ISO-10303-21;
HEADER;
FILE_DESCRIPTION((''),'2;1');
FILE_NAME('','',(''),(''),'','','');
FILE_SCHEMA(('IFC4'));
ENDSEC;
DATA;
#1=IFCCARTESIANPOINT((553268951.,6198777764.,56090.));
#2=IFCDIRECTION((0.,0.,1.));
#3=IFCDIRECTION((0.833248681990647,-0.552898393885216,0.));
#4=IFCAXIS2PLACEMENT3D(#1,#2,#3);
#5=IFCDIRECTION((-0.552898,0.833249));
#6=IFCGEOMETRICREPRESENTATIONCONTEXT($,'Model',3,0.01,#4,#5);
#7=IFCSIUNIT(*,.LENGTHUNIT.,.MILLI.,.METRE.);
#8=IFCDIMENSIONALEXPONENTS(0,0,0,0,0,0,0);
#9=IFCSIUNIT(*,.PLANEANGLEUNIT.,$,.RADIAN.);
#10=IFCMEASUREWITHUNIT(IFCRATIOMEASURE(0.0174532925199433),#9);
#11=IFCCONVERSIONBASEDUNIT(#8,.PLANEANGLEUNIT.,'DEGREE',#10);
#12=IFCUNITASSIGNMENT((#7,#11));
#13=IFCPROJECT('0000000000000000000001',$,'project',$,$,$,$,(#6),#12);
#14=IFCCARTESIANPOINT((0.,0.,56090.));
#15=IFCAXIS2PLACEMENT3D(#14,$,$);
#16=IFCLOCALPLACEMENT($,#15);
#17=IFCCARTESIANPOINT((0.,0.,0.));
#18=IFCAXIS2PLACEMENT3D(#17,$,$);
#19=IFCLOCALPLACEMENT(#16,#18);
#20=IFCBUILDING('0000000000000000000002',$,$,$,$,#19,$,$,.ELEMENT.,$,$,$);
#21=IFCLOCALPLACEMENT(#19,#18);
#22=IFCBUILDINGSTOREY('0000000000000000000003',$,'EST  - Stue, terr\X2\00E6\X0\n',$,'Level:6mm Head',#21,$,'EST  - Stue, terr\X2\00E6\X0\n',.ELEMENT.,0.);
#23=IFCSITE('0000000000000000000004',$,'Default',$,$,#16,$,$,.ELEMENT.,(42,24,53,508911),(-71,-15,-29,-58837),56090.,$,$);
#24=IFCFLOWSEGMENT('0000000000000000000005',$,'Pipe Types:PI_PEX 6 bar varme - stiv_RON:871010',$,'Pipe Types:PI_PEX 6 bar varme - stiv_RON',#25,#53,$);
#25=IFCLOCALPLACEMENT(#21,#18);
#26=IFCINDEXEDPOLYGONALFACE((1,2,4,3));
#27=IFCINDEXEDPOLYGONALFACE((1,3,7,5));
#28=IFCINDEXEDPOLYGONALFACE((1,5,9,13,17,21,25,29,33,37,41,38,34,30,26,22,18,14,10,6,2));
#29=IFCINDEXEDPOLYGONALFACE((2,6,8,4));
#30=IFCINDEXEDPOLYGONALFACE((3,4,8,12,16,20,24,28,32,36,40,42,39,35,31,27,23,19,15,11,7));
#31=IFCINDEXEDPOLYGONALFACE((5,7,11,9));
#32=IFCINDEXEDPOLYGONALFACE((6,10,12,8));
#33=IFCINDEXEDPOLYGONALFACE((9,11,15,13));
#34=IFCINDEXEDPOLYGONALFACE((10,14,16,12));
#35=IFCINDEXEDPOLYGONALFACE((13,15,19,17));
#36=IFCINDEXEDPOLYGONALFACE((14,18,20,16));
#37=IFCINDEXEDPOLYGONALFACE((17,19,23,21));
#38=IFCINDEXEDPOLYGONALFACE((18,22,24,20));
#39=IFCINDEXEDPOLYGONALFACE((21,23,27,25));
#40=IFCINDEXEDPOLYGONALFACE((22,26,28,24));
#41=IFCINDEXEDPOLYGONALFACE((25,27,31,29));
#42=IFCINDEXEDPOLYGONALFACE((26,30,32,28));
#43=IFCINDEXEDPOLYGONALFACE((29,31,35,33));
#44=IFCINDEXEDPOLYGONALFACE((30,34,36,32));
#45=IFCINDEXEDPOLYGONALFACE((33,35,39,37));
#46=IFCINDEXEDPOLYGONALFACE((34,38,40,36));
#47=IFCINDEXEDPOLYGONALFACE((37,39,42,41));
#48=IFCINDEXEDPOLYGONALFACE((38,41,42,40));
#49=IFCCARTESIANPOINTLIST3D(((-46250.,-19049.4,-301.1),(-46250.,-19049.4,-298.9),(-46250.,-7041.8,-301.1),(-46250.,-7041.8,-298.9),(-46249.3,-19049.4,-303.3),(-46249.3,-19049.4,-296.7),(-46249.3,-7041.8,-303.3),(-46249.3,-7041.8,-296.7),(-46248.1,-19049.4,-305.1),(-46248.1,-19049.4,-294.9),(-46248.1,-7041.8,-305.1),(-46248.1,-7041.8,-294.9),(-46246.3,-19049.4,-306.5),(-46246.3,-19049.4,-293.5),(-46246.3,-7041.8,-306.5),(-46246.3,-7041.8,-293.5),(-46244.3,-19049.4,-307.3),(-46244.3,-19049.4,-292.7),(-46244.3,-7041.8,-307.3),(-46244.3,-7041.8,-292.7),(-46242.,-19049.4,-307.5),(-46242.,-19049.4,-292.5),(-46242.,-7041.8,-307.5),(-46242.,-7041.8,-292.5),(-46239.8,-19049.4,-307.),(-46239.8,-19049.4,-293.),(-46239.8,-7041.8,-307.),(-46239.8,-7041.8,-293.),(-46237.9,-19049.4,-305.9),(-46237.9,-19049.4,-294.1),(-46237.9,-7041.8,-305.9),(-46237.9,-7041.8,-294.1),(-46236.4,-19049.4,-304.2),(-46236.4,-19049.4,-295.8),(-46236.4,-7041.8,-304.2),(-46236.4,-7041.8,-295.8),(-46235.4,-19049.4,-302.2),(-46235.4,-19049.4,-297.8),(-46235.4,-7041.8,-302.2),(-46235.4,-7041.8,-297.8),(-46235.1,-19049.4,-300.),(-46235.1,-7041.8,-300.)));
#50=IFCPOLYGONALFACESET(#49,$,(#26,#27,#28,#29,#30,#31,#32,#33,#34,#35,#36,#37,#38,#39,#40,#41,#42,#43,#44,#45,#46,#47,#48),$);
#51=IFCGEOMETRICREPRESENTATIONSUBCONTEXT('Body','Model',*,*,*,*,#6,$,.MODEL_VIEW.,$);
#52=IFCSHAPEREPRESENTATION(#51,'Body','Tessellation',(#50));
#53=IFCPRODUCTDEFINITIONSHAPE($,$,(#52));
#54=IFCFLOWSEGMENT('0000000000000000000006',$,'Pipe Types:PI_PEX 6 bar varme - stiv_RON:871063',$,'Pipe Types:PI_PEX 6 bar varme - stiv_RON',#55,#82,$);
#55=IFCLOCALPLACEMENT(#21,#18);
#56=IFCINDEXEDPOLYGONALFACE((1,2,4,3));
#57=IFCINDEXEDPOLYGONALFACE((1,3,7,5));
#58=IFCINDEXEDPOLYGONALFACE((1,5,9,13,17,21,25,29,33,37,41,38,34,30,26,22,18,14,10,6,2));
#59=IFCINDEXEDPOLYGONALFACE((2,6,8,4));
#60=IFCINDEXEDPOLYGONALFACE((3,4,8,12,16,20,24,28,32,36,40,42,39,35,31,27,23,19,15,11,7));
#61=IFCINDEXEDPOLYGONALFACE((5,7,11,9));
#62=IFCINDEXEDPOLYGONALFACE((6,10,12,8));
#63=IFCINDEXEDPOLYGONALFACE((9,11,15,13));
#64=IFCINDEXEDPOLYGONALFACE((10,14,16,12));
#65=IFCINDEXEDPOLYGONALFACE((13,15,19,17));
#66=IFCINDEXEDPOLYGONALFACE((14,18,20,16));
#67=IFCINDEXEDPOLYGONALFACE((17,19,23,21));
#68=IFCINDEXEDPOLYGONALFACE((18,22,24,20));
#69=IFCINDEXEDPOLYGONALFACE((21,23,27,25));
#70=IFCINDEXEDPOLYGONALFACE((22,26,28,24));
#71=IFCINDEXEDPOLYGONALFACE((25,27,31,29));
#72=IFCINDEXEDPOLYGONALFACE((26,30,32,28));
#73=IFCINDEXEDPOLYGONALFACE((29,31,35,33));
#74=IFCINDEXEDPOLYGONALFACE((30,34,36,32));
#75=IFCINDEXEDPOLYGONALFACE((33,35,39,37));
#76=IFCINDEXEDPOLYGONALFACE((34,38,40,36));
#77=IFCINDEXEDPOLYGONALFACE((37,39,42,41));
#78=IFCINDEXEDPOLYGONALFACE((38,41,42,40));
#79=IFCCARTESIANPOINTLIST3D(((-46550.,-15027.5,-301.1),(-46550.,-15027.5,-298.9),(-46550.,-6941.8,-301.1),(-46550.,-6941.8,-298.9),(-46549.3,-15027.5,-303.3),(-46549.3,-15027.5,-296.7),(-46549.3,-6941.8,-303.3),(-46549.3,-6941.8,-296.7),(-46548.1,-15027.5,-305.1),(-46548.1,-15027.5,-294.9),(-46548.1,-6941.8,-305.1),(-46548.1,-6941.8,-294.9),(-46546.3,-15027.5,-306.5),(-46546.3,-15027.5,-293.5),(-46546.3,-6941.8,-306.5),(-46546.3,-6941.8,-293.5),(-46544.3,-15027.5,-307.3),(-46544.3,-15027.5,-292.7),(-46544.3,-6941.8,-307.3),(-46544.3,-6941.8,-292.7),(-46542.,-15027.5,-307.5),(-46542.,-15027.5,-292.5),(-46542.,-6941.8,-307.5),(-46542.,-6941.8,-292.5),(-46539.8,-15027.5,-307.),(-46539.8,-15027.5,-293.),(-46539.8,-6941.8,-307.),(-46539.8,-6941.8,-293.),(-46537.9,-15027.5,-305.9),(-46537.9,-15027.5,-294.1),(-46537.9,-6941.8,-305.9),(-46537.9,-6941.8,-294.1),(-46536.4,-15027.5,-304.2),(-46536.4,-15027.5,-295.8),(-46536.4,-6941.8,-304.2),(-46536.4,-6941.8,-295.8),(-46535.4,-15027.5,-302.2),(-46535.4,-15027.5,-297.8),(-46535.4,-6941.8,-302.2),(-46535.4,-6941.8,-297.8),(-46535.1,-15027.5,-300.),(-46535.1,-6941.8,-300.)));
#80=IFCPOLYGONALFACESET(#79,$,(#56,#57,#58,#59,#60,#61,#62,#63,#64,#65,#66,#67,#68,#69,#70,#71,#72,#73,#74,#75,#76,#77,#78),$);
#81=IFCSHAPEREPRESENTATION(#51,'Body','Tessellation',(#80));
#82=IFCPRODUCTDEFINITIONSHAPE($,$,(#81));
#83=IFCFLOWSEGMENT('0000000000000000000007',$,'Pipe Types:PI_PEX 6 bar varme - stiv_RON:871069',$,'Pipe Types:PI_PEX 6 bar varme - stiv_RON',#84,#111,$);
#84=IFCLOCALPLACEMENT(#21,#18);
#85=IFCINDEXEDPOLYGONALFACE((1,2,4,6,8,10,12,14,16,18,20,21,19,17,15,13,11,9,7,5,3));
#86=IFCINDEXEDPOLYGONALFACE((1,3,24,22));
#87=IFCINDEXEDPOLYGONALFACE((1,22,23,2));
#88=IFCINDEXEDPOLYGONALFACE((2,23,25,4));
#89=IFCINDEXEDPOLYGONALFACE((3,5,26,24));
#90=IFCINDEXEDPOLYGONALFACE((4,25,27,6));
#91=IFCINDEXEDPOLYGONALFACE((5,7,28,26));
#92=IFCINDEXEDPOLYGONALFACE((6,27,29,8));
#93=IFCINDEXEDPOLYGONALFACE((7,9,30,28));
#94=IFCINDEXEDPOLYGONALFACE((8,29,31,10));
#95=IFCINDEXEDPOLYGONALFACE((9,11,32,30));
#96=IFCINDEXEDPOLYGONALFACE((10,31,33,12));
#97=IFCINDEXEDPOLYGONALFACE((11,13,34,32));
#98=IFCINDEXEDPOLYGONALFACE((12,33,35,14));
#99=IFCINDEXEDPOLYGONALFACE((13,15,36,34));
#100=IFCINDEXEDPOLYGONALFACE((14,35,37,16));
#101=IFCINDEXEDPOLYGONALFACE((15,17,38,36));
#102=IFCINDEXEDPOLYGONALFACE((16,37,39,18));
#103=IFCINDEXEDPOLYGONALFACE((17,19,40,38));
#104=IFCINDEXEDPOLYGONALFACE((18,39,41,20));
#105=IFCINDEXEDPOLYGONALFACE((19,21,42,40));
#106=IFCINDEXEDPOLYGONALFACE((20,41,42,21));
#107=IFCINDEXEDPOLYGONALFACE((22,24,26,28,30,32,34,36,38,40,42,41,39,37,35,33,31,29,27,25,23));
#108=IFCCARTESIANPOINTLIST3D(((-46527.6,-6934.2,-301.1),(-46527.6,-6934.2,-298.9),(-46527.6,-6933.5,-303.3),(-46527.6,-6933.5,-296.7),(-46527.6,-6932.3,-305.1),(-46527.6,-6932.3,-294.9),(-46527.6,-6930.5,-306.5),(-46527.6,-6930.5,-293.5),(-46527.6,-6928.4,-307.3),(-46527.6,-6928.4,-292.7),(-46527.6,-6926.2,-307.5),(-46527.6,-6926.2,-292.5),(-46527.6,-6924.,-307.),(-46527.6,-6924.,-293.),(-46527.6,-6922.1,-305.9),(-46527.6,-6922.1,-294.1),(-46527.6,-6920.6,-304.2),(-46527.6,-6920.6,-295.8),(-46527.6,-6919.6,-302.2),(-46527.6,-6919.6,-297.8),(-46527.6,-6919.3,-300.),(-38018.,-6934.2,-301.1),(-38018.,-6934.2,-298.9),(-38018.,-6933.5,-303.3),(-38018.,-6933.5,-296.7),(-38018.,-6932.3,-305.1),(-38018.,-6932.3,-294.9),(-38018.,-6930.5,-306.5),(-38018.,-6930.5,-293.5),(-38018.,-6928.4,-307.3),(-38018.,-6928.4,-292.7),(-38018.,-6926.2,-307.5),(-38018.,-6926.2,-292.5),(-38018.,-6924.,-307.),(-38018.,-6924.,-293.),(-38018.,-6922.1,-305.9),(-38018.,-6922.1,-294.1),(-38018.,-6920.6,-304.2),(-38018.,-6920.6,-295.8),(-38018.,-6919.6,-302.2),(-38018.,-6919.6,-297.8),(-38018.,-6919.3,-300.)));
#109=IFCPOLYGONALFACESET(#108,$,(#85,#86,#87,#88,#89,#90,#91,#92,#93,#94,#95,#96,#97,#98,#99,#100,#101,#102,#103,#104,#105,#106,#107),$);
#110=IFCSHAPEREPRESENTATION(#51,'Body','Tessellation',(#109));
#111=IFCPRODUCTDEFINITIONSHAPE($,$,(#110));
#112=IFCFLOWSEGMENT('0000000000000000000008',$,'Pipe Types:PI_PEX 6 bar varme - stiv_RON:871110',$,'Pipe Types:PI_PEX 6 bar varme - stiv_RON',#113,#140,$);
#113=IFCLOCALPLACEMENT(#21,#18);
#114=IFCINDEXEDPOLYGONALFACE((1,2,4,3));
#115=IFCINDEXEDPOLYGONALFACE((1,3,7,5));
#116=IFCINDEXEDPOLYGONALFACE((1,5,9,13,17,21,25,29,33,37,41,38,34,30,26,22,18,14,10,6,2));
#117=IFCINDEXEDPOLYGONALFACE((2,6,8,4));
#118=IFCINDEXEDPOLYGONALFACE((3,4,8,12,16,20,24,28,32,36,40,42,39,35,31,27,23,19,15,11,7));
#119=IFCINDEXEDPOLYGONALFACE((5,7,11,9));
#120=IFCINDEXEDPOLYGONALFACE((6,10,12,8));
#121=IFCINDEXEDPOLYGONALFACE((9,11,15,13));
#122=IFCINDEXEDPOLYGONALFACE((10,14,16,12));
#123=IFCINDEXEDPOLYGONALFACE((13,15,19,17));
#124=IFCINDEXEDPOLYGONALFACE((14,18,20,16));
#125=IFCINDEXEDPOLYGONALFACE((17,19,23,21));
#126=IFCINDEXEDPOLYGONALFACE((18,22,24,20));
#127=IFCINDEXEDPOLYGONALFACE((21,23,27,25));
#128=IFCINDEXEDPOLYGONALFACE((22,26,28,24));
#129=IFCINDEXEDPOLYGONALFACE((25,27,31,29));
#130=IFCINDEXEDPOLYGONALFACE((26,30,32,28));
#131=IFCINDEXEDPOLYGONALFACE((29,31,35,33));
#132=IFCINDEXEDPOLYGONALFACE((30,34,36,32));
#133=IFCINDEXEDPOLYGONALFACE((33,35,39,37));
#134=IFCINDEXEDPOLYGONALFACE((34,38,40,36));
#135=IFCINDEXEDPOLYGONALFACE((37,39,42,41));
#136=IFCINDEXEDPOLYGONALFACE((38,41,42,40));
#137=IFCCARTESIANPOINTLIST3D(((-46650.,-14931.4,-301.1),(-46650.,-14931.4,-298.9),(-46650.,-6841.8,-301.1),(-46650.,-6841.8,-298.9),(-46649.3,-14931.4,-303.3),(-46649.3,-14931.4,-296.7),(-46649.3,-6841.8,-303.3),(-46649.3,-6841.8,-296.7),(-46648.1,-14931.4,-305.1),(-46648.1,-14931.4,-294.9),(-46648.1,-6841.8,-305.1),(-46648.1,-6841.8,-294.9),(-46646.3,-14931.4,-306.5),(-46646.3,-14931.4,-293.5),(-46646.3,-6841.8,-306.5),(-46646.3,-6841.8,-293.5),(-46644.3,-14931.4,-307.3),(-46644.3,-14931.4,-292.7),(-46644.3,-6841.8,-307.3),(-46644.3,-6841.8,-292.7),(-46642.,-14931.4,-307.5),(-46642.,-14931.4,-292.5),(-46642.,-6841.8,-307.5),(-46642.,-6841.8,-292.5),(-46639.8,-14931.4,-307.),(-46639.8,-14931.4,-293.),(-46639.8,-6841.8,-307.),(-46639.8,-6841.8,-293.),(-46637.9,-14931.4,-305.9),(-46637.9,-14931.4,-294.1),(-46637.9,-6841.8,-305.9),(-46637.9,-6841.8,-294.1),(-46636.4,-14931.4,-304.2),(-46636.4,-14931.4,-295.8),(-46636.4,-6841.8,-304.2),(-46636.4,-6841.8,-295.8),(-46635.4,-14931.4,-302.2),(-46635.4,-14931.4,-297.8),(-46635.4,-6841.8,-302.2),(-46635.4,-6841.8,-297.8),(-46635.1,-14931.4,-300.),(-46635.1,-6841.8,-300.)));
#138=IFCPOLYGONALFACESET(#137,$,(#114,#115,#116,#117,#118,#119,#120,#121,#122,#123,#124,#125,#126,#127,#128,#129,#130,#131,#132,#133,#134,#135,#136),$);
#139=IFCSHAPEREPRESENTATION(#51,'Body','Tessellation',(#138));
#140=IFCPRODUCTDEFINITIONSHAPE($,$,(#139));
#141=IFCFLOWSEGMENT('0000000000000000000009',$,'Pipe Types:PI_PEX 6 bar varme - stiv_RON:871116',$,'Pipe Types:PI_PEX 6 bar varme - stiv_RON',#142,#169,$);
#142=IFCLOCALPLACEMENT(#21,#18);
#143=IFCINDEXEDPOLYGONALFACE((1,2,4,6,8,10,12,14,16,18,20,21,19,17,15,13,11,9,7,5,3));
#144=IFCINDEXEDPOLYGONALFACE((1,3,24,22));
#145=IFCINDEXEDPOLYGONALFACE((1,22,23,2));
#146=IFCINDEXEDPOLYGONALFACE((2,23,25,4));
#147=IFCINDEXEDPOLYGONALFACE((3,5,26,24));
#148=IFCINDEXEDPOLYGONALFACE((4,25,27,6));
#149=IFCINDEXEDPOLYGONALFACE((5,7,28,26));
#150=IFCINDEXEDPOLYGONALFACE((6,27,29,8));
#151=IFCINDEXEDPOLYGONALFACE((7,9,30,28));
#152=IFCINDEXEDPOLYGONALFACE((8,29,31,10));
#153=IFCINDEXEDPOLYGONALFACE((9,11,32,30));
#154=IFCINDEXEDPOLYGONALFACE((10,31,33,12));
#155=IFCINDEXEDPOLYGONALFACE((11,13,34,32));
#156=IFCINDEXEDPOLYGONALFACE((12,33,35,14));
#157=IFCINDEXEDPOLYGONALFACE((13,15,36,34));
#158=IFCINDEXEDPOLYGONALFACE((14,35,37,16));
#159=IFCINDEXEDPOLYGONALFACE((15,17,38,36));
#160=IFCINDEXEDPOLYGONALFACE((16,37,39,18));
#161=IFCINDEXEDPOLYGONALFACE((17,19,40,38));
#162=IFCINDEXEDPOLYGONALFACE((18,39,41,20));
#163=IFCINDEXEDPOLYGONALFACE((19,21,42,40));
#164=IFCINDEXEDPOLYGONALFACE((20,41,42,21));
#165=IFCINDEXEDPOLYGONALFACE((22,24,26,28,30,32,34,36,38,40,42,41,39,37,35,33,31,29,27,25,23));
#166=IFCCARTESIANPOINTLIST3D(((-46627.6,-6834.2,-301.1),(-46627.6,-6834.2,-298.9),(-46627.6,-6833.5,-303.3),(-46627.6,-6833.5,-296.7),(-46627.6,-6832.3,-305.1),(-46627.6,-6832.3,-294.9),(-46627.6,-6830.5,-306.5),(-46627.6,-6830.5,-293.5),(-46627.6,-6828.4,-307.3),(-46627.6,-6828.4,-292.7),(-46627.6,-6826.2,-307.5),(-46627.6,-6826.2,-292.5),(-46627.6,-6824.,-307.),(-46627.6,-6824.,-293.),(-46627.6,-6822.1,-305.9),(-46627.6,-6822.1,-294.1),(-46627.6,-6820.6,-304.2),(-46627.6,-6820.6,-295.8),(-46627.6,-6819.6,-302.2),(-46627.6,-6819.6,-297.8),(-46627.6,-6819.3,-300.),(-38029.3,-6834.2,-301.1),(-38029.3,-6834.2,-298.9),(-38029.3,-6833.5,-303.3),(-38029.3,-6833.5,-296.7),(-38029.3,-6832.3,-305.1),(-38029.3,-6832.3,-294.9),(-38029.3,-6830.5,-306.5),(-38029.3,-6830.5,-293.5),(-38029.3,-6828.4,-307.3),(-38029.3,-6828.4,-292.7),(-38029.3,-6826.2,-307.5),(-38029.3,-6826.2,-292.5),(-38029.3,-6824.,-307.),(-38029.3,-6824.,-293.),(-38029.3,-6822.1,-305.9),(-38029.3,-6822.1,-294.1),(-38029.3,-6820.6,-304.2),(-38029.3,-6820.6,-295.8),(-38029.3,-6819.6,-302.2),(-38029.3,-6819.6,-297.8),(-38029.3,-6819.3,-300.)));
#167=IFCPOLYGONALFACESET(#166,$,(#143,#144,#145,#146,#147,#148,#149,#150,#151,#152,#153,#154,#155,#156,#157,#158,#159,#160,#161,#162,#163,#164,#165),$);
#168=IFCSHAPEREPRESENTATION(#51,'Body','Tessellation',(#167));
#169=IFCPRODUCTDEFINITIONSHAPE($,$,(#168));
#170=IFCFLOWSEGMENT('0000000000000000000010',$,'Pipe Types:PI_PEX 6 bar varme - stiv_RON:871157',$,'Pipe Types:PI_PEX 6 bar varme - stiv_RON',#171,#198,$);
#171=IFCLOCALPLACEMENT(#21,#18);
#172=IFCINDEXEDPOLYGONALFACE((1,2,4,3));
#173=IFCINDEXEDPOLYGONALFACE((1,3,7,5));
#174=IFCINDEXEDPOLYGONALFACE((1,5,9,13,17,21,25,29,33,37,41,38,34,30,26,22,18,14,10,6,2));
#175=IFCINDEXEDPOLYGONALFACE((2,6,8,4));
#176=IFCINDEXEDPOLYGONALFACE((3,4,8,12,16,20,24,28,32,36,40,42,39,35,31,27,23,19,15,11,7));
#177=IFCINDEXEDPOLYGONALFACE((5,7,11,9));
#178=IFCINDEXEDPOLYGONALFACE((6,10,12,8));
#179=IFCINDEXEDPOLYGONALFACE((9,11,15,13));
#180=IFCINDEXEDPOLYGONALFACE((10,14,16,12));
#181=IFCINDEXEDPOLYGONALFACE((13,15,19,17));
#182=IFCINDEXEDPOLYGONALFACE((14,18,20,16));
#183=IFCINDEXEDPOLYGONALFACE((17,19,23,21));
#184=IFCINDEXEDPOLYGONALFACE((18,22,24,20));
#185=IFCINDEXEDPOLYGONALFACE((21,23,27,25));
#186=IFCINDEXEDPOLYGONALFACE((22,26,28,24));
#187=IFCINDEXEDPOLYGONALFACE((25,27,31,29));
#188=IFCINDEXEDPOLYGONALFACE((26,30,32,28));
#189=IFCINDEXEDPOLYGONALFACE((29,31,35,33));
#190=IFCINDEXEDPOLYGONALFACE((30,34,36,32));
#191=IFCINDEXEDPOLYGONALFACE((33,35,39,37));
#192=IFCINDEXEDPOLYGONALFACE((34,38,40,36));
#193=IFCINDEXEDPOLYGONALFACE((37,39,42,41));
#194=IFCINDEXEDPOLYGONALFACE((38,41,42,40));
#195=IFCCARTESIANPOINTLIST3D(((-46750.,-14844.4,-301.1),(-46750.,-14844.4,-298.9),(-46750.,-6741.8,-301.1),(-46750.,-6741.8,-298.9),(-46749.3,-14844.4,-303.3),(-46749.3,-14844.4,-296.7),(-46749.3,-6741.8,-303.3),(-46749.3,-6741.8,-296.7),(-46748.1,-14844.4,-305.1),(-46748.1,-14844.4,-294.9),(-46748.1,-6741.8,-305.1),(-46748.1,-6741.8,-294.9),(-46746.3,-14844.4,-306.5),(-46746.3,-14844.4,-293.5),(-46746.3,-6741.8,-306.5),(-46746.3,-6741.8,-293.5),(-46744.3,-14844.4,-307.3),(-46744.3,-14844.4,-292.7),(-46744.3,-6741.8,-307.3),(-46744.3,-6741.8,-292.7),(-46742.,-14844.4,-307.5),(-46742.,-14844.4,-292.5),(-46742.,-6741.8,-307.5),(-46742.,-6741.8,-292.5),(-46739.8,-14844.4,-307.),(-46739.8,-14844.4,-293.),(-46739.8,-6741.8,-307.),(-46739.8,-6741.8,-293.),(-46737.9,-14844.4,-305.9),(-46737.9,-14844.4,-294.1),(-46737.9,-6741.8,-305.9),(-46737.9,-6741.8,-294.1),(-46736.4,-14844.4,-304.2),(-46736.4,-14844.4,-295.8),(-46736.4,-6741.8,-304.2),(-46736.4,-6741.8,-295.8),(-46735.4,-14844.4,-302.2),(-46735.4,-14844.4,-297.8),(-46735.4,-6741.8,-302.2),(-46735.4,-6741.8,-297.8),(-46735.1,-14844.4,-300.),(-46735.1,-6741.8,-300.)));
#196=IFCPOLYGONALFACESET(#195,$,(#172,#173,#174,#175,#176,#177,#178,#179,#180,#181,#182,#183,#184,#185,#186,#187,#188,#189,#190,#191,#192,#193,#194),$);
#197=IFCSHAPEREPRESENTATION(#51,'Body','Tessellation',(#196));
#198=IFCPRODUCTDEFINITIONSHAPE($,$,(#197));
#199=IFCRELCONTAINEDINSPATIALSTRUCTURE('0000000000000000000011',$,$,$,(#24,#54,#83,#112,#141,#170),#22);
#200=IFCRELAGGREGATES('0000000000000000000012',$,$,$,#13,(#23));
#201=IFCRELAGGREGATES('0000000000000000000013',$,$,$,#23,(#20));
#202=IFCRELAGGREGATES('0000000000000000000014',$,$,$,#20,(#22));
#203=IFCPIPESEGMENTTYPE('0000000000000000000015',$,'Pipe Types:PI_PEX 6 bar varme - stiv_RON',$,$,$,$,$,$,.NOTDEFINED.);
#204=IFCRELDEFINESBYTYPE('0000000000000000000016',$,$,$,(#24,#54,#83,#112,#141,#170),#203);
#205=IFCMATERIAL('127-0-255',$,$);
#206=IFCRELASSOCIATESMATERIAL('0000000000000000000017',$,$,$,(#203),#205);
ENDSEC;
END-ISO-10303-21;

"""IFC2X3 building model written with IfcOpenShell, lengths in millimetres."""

from ifc_helpers import new_model, entity, si_unit, converted_unit, direction, frame, frame_2d, origin, origin_2d_with_axis, place, context, subcontext, project, spatial, circle, extrude, material, type_object, element, save


model = new_model("IFC2X3")

# Units and contexts
model_context = context("Model", 3, precision=0.01, world=frame((553268951.0, 6198777764.0, 56090.0), z_axis=(0.0, 0.0, 1.0), x_axis=(0.833248681990647, -0.552898393885216, 0.0)), true_north=direction((-0.552898, 0.833249)))
body_context = subcontext(model_context, "Body", "Model", "MODEL_VIEW")
ifc_project = project(units=[si_unit("LENGTHUNIT", "METRE", prefix="MILLI"), converted_unit("PLANEANGLEUNIT", "DEGREE", entity("IfcRatioMeasure", 0.0174532925199433), si_unit("PLANEANGLEUNIT", "RADIAN"), dimensions=[0, 0, 0, 0, 0, 0, 0])], contexts=[model_context])

# Site, building, storey
site_placement = place(None, frame((0.0, 0.0, 56090.0)))
site = spatial("IfcSite", under=ifc_project, at=site_placement, Name="Default", CompositionType="ELEMENT", RefLatitude=(42, 24, 53, 508911), RefLongitude=(-71, -15, -29, -58837), RefElevation=56090.0)
building_placement = place(site_placement, origin())
building = spatial("IfcBuilding", under=site, at=building_placement, CompositionType="ELEMENT")
storey_placement = place(building_placement, frame((0.0, 0.0, 0.0)))
storey = spatial("IfcBuildingStorey", under=building, at=storey_placement, Name="EST  - Stue, terræn", ObjectType="Level:6mm Head", LongName="EST  - Stue, terræn", CompositionType="ELEMENT", Elevation=0.0)

# Flow segments
ifc_material = material(Name="127-0-255")
pipe_segment_type = type_object("IfcPipeSegmentType", Name="Pipe Types:PI_PEX 6 bar varme - stiv_RON", PredefinedType="NOTDEFINED", material=ifc_material)
flow_segment_1_placement = place(storey_placement, origin())
element("IfcFlowSegment", 1, at=flow_segment_1_placement, inside=storey, type_object=pipe_segment_type, Name="Pipe Types:PI_PEX 6 bar varme - stiv_RON:871010", ObjectType="Pipe Types:PI_PEX 6 bar varme - stiv_RON", context=body_context, shape_type="SweptSolid", body=[
    extrude(circle(Radius=7.5, at=origin_2d_with_axis()), frame((-46242.6, -19049.4, -300.0), z_axis=(0.0, 1.0, 0.0), x_axis=(1.0, 0.0, 0.0)), (0.0, 0.0, 1.0), 12007.6),
])
flow_segment_2_placement = place(storey_placement, origin())
element("IfcFlowSegment", 2, at=flow_segment_2_placement, inside=storey, type_object=pipe_segment_type, Name="Pipe Types:PI_PEX 6 bar varme - stiv_RON:871063", ObjectType="Pipe Types:PI_PEX 6 bar varme - stiv_RON", context=body_context, shape_type="SweptSolid", body=[
    extrude(circle(Radius=7.5, at=origin_2d_with_axis()), frame((-46542.6, -15027.5, -300.0), z_axis=(0.0, 1.0, 0.0), x_axis=(1.0, 0.0, 0.0)), (0.0, 0.0, 1.0), 8085.7),
])
flow_segment_3_placement = place(storey_placement, origin())
element("IfcFlowSegment", 3, at=flow_segment_3_placement, inside=storey, type_object=pipe_segment_type, Name="Pipe Types:PI_PEX 6 bar varme - stiv_RON:871069", ObjectType="Pipe Types:PI_PEX 6 bar varme - stiv_RON", context=body_context, shape_type="SweptSolid", body=[
    extrude(circle(Radius=7.5, at=frame_2d((0.0, 0.0), x_axis=(1.0, 0.0))), frame((-46527.6, -6926.8, -300.0), z_axis=(1.0, 0.0, 0.0), x_axis=(0.0, 1.0, 0.0)), (0.0, 0.0, 1.0), 8509.6),
])
flow_segment_4_placement = place(storey_placement, origin())
element("IfcFlowSegment", 4, at=flow_segment_4_placement, inside=storey, type_object=pipe_segment_type, Name="Pipe Types:PI_PEX 6 bar varme - stiv_RON:871110", ObjectType="Pipe Types:PI_PEX 6 bar varme - stiv_RON", context=body_context, shape_type="SweptSolid", body=[
    extrude(circle(Radius=7.5, at=origin_2d_with_axis()), frame((-46642.6, -14931.4, -300.0), z_axis=(0.0, 1.0, 0.0), x_axis=(1.0, 0.0, 0.0)), (0.0, 0.0, 1.0), 8089.6),
])
flow_segment_5_placement = place(storey_placement, origin())
element("IfcFlowSegment", 5, at=flow_segment_5_placement, inside=storey, type_object=pipe_segment_type, Name="Pipe Types:PI_PEX 6 bar varme - stiv_RON:871116", ObjectType="Pipe Types:PI_PEX 6 bar varme - stiv_RON", context=body_context, shape_type="SweptSolid", body=[
    extrude(circle(Radius=7.5, at=frame_2d((0.0, 0.0), x_axis=(1.0, 0.0))), frame((-46627.6, -6826.8, -300.0), z_axis=(1.0, 0.0, 0.0), x_axis=(0.0, 1.0, 0.0)), (0.0, 0.0, 1.0), 8598.3),
])
flow_segment_6_placement = place(storey_placement, origin())
element("IfcFlowSegment", 6, at=flow_segment_6_placement, inside=storey, type_object=pipe_segment_type, Name="Pipe Types:PI_PEX 6 bar varme - stiv_RON:871157", ObjectType="Pipe Types:PI_PEX 6 bar varme - stiv_RON", context=body_context, shape_type="SweptSolid", body=[
    extrude(circle(Radius=7.5, at=origin_2d_with_axis()), frame((-46742.6, -14844.4, -300.0), z_axis=(0.0, 1.0, 0.0), x_axis=(1.0, 0.0, 0.0)), (0.0, 0.0, 1.0), 8102.6),
])

save(model, "model.ifc")
